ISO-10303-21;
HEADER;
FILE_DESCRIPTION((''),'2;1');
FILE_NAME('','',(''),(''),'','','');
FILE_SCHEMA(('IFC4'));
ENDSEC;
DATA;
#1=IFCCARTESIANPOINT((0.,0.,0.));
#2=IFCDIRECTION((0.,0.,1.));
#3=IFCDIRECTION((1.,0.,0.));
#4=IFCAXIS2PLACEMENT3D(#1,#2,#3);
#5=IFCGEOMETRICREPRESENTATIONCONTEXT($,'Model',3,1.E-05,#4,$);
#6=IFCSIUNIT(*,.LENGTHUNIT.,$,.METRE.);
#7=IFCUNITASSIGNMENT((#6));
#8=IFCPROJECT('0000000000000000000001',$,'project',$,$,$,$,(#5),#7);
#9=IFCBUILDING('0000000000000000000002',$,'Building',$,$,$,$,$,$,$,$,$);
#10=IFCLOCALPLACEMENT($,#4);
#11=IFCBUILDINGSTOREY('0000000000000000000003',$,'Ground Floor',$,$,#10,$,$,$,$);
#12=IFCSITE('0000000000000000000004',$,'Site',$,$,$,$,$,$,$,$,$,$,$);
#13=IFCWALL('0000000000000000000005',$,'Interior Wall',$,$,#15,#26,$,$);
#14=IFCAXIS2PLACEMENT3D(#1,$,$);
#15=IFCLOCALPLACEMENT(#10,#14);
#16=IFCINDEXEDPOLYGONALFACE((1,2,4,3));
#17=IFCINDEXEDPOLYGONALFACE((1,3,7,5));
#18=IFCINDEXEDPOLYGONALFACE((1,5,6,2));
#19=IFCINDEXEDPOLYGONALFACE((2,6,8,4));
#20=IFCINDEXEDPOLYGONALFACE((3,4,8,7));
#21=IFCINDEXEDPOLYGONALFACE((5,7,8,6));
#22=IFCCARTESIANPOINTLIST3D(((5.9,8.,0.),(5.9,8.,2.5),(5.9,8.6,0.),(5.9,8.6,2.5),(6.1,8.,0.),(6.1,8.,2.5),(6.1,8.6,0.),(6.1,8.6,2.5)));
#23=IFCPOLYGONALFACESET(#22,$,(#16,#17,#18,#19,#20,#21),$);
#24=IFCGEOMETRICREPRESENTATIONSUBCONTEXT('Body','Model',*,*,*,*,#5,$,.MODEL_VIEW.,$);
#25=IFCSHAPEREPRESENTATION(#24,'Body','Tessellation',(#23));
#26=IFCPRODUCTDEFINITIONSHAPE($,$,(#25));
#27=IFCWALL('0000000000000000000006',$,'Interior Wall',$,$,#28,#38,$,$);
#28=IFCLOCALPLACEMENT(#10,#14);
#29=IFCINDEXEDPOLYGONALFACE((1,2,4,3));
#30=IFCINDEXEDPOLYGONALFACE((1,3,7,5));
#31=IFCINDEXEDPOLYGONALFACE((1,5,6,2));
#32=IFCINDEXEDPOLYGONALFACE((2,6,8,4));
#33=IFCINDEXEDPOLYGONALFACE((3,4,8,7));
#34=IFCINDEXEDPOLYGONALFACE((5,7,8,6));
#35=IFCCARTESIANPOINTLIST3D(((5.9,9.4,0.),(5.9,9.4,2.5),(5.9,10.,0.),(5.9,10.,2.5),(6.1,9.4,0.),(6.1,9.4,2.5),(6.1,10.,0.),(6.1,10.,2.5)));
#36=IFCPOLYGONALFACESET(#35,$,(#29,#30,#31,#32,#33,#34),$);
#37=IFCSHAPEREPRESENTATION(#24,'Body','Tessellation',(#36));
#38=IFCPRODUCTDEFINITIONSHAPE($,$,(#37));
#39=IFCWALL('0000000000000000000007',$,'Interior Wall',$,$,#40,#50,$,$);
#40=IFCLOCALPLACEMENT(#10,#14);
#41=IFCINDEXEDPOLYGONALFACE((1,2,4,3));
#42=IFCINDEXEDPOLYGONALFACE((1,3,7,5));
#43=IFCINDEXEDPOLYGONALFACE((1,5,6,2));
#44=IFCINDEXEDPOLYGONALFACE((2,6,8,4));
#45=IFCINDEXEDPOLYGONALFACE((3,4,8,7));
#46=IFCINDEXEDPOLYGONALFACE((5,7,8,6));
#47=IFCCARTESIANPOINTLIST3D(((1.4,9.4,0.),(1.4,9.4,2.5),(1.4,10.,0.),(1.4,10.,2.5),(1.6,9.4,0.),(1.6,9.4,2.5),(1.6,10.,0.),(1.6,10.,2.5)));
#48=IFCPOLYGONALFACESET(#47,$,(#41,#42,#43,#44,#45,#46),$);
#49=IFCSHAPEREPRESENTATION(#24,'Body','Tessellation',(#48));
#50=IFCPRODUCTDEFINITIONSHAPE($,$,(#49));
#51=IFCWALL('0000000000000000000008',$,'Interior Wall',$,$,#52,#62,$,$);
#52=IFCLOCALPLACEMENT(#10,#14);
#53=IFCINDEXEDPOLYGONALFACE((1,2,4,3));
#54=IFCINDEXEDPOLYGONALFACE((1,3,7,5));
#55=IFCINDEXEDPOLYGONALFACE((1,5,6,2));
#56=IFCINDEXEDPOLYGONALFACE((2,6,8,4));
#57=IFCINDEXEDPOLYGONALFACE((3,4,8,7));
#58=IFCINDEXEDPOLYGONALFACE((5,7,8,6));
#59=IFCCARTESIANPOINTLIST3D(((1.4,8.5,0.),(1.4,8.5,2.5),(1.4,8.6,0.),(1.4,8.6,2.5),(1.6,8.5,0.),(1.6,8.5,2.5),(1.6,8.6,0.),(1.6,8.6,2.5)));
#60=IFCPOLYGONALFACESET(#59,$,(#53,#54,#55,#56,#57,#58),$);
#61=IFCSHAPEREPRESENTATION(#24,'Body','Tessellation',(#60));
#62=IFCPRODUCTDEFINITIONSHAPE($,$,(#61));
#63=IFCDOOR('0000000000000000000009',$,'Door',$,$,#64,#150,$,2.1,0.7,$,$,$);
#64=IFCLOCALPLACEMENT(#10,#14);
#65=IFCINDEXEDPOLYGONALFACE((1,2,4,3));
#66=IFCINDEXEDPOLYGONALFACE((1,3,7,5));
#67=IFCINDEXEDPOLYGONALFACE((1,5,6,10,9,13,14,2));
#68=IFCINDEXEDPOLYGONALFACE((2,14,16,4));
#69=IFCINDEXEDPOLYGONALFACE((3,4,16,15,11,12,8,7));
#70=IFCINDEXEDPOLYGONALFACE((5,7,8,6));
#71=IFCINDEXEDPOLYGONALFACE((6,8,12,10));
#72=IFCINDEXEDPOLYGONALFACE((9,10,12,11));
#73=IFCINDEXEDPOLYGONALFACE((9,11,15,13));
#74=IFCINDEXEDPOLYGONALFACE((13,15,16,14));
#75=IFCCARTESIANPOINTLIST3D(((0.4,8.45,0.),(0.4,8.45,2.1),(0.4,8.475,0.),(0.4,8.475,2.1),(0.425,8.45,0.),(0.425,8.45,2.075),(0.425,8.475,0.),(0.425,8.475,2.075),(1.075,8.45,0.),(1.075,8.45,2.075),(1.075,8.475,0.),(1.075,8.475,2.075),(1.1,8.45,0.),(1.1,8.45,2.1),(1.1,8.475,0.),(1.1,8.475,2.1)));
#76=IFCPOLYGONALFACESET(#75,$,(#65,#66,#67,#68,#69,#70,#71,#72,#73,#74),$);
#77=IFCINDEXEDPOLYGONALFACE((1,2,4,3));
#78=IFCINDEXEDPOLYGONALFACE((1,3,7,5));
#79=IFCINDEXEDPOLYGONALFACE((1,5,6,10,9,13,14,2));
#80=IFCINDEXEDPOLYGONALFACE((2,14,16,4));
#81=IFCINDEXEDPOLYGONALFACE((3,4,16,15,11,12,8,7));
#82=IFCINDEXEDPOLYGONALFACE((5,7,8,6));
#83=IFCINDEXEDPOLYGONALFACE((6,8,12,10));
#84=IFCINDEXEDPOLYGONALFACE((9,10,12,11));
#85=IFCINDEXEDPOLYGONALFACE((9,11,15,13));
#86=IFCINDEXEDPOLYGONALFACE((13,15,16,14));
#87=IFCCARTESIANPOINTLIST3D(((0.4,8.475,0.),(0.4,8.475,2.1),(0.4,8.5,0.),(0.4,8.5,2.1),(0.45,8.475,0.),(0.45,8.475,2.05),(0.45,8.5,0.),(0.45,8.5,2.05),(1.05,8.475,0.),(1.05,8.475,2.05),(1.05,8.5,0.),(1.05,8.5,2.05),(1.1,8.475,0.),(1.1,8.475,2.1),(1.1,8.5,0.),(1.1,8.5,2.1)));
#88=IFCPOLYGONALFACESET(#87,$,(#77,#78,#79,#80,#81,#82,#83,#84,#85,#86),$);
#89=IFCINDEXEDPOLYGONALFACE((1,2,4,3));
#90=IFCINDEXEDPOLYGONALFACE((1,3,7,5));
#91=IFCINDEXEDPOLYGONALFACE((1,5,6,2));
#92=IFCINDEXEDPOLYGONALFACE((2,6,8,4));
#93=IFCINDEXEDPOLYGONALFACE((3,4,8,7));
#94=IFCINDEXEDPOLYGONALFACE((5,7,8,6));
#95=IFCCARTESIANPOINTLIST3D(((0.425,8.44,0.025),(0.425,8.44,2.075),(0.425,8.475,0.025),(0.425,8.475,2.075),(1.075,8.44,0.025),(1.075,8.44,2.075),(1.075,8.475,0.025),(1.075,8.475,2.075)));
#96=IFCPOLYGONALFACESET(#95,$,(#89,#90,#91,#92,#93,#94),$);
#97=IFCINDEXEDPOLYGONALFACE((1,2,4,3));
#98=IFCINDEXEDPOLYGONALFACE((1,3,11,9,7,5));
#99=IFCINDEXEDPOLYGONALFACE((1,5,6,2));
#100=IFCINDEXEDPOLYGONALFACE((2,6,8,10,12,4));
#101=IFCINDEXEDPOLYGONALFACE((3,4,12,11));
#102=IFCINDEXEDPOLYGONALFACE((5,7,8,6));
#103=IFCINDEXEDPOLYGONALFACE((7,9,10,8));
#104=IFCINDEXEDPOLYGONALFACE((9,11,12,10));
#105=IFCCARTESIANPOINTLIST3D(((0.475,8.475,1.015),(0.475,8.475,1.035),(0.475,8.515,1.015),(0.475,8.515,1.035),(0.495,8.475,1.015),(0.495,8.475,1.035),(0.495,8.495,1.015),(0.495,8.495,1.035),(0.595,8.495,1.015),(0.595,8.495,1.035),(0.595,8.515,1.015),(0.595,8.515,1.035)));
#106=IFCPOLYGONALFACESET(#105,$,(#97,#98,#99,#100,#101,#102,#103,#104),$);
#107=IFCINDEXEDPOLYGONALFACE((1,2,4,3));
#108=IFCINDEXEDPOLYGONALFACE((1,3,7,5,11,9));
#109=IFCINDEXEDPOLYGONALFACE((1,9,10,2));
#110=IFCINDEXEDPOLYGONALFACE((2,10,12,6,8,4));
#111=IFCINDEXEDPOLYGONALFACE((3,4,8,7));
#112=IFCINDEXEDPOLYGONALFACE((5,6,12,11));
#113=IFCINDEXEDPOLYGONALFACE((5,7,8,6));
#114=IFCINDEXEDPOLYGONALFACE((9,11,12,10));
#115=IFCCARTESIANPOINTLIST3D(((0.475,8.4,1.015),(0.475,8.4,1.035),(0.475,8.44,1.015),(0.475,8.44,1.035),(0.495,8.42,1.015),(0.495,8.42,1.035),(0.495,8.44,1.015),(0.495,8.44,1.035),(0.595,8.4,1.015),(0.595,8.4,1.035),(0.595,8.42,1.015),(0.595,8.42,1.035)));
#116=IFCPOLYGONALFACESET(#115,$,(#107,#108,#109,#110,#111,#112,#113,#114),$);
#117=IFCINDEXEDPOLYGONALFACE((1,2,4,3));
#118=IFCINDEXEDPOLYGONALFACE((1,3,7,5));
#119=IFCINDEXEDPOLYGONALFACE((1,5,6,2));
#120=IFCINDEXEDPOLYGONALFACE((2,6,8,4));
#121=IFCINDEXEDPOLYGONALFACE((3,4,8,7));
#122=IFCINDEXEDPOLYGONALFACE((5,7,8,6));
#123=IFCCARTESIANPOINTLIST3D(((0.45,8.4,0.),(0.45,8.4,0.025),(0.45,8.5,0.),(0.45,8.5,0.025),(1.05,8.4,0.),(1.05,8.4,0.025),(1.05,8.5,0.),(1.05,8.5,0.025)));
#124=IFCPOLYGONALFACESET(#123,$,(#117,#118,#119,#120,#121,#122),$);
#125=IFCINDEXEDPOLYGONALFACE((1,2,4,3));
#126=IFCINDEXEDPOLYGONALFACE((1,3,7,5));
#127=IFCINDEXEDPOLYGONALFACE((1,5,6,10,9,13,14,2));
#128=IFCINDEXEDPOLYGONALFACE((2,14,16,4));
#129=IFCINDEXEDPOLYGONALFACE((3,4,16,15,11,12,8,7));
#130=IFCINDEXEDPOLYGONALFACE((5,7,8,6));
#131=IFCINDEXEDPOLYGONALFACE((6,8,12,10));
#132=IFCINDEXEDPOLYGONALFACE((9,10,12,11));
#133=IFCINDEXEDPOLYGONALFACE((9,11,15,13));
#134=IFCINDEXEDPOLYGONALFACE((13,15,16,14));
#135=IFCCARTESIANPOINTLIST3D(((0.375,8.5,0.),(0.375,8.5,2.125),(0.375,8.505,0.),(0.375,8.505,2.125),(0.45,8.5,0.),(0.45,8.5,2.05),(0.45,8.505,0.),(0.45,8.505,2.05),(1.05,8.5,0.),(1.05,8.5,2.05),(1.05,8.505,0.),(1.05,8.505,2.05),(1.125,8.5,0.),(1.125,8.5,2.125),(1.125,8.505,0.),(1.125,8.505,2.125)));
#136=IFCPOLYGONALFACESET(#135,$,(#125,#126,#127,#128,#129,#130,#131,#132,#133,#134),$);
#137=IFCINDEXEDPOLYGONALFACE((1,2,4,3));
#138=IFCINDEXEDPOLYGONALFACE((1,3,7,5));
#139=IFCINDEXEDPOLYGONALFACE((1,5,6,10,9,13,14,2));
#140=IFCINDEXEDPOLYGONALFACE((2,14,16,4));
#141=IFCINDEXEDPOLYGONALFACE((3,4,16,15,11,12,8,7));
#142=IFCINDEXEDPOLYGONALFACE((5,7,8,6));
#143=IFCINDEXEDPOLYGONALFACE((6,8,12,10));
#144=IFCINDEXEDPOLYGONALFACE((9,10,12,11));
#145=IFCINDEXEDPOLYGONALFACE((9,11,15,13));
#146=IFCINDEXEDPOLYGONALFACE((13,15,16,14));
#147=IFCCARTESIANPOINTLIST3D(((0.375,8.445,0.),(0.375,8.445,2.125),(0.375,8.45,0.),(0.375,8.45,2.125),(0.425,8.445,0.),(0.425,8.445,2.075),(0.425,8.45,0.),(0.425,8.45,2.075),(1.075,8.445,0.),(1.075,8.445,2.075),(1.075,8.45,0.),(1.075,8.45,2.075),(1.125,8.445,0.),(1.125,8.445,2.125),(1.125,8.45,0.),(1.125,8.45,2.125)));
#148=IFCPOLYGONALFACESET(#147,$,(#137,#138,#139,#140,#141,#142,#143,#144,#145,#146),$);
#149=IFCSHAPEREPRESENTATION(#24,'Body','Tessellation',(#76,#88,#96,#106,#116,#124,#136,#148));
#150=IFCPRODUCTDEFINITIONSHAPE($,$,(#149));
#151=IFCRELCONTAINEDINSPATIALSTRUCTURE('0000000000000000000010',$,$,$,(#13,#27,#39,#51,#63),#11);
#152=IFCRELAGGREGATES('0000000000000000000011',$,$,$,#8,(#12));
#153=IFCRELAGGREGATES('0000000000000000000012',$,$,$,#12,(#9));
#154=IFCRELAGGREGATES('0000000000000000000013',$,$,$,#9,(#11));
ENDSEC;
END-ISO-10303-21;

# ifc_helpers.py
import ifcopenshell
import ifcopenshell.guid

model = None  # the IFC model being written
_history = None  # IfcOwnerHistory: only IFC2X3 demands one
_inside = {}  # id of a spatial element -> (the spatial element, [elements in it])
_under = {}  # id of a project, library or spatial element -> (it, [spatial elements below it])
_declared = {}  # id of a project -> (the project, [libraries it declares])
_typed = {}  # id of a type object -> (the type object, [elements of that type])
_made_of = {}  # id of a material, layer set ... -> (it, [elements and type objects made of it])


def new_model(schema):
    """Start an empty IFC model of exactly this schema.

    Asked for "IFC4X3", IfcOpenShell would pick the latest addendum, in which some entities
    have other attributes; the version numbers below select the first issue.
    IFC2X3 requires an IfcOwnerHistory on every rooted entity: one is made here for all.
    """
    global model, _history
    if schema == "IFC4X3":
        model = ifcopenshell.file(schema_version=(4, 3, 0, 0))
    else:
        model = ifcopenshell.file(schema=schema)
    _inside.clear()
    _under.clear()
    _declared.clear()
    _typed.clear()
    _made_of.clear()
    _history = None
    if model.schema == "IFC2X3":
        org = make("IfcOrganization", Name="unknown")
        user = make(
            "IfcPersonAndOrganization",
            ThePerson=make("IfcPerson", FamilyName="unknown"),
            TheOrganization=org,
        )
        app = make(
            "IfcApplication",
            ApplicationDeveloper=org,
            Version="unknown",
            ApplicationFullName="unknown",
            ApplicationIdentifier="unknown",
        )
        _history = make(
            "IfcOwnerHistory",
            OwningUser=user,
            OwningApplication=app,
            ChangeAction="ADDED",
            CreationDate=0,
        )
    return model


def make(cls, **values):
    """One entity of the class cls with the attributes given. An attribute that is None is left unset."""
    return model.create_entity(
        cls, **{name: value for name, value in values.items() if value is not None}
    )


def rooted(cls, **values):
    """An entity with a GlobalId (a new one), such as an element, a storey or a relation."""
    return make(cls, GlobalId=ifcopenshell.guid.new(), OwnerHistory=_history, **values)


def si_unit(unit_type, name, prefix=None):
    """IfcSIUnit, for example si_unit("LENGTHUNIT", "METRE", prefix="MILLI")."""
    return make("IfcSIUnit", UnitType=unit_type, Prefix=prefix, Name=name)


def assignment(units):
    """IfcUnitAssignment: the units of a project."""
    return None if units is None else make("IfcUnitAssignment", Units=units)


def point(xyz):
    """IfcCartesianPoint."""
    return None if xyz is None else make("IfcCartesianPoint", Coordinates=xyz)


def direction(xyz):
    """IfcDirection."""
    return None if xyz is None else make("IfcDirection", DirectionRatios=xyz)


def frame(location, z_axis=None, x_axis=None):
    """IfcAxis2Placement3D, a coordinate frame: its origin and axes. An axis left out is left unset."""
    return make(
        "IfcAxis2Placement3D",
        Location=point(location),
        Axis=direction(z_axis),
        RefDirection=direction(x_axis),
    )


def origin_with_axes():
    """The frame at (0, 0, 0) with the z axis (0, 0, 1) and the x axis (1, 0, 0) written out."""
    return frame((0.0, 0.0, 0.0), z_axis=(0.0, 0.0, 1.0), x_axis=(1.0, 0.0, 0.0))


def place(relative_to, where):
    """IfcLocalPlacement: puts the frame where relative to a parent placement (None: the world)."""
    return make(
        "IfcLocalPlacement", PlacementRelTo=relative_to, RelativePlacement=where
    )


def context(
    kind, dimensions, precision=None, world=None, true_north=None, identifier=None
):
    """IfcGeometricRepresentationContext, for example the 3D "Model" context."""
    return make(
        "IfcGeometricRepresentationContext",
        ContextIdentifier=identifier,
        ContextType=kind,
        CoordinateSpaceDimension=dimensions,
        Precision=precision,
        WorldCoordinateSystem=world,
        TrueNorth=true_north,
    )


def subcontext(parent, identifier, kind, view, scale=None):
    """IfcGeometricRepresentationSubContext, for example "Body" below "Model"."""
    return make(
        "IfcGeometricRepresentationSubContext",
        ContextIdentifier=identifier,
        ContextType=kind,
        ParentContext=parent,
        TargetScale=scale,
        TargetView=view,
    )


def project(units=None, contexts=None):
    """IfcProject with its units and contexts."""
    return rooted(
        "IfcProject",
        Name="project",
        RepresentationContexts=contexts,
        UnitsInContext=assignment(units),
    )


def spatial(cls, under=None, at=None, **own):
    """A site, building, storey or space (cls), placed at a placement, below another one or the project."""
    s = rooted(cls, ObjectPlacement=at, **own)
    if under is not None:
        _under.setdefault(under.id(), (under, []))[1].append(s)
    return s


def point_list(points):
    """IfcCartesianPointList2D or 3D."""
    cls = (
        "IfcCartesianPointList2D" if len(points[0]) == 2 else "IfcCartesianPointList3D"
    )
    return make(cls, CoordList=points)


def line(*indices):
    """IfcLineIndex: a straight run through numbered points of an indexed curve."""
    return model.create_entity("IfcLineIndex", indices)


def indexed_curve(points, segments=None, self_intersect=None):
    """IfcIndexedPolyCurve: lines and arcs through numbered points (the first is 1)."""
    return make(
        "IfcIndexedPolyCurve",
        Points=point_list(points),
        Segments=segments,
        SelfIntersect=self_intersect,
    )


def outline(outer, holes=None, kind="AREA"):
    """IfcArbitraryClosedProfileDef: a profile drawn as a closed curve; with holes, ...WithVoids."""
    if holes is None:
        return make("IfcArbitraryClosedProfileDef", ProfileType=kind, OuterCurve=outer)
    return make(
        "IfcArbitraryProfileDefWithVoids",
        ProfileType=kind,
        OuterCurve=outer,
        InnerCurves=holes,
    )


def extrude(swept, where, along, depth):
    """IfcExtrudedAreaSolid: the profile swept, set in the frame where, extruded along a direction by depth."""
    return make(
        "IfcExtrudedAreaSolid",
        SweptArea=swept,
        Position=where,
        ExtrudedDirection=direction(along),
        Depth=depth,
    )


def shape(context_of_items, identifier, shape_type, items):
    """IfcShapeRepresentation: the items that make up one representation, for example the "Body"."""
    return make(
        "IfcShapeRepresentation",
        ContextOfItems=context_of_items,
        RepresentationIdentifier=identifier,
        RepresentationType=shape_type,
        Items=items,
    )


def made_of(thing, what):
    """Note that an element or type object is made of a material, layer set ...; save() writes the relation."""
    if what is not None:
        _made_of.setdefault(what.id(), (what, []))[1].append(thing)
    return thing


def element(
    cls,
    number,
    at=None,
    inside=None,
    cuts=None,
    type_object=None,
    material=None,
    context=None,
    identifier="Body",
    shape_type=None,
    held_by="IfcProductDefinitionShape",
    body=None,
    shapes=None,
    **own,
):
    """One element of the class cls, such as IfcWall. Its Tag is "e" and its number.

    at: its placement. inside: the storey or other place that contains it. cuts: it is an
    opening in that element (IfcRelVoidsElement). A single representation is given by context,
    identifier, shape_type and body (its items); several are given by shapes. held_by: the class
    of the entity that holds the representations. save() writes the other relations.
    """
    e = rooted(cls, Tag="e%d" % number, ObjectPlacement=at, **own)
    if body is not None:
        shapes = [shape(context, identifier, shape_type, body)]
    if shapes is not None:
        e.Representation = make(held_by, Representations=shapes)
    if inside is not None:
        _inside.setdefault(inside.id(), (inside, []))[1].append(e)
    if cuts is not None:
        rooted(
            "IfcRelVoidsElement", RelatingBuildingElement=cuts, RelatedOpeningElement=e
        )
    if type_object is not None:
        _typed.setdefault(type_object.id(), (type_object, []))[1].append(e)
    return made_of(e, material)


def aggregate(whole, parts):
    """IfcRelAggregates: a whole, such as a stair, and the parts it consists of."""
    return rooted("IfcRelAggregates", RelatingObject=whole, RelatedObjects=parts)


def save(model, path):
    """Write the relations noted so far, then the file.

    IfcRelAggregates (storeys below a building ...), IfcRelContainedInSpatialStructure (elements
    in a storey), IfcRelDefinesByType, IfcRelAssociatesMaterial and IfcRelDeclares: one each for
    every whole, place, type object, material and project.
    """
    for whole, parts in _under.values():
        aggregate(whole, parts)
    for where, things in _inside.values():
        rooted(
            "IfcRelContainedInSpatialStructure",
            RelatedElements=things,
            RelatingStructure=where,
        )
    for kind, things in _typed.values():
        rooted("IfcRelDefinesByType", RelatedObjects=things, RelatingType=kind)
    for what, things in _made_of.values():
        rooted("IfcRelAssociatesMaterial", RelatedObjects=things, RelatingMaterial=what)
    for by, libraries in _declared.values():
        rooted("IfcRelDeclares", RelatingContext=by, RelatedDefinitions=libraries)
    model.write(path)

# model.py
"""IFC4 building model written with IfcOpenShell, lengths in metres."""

from ifc_helpers import new_model, si_unit, frame, origin_with_axes, place, context, subcontext, project, spatial, line, indexed_curve, outline, extrude, element, save


model = new_model("IFC4")

# Units and contexts
model_context = context("Model", 3, precision=1e-05, world=origin_with_axes())
body_context = subcontext(model_context, "Body", "Model", "MODEL_VIEW")
ifc_project = project(units=[si_unit("LENGTHUNIT", "METRE")], contexts=[model_context])

# Site, building, storey
site = spatial("IfcSite", under=ifc_project, Name="Site")
building = spatial("IfcBuilding", under=site, Name="Building")
storey_placement = place(None, origin_with_axes())
storey = spatial("IfcBuildingStorey", under=building, at=storey_placement, Name="Ground Floor")

# Walls
for number, where, z_axis, x_axis, name in (
    (1, (6.0, 8.0, 0.0), (0.0, 0.0, 1.0), (0.0, 1.0, 0.0), "Interior Wall"),
    (2, (6.0, 9.4, 0.0), (0.0, 0.0, 1.0), (0.0, 1.0, 0.0), "Interior Wall"),
    (3, (1.5, 10.0, 0.0), (0.0, 0.0, 1.0), (0.0, -1.0, 0.0), "Interior Wall"),
):
    element("IfcWall", number, at=place(storey_placement, frame(where, z_axis=z_axis, x_axis=x_axis)), inside=storey, Name=name, context=body_context, shape_type="SweptSolid", body=[
        extrude(outline(indexed_curve([(0.0, 0.0), (0.0, 0.2), (0.6, 0.2), (0.6, 0.0), (0.0, 0.0)], self_intersect=False)), frame((0.0, -0.1, 0.0), z_axis=(0.0, 0.0, 1.0), x_axis=(1.0, 0.0, 0.0)), (0.0, 0.0, 1.0), 2.5),
    ])
wall_1_placement = place(storey_placement, frame((1.5, 8.6, 0.0), z_axis=(0.0, 0.0, 1.0), x_axis=(0.0, -1.0, 0.0)))
element("IfcWall", 4, at=wall_1_placement, inside=storey, Name="Interior Wall", context=body_context, shape_type="SweptSolid", body=[
    extrude(outline(indexed_curve([(0.0, 0.0), (0.0, 0.2), (0.1, 0.2), (0.1, 0.0), (0.0, 0.0)], self_intersect=False)), frame((0.0, -0.1, 0.0), z_axis=(0.0, 0.0, 1.0), x_axis=(1.0, 0.0, 0.0)), (0.0, 0.0, 1.0), 2.5),
])

# Door
door_1_placement = place(storey_placement, frame((1.1, 8.5, 0.0), z_axis=(0.0, 0.0, 1.0), x_axis=(-1.0, 0.0, 0.0)))
element("IfcDoor", 5, at=door_1_placement, inside=storey, Name="Door", OverallHeight=2.1, OverallWidth=0.7, context=body_context, shape_type="SweptSolid", body=[
    extrude(outline(indexed_curve([(0.0, 0.0), (0.0, 2.1), (0.7, 2.1), (0.7, 0.0), (0.675, 0.0), (0.675, 2.075), (0.025, 2.075), (0.025, 0.0)], segments=[line(1, 2, 3, 4, 5, 6, 7, 8, 1)])), frame((0.0, 0.025, 0.0), z_axis=(0.0, -1.0, 0.0), x_axis=(1.0, 0.0, 0.0)), (0.0, 0.0, -1.0), 0.025),
    extrude(outline(indexed_curve([(0.0, 0.0), (0.0, 2.1), (0.7, 2.1), (0.7, 0.0), (0.65, 0.0), (0.65, 2.05), (0.05, 2.05), (0.05, 0.0)], segments=[line(1, 2, 3, 4, 5, 6, 7, 8, 1)])), frame((0.0, 0.0, 0.0), z_axis=(0.0, -1.0, 0.0), x_axis=(1.0, 0.0, 0.0)), (0.0, 0.0, -1.0), 0.025),
    extrude(outline(indexed_curve([(0.0, 0.0), (0.65, 0.0), (0.65, 0.035), (0.0, 0.035)], segments=[line(1, 2, 3, 4, 1)])), frame((0.025, 0.025, 0.025), z_axis=(0.0, 0.0, 1.0), x_axis=(1.0, 0.0, 0.0)), (0.0, 0.0, 1.0), 2.05),
    extrude(outline(indexed_curve([(0.0, 0.0), (0.0, -0.04), (-0.12, -0.04), (-0.12, -0.02), (-0.02, -0.02), (-0.02, 0.0)], segments=[line(1, 2, 3, 4, 5, 6, 1)])), frame((0.625, 0.025, 1.015), z_axis=(0.0, 0.0, 1.0), x_axis=(1.0, 0.0, 0.0)), (0.0, 0.0, 1.0), 0.02),
    extrude(outline(indexed_curve([(0.0, 0.0), (0.0, 0.04), (-0.12, 0.04), (-0.12, 0.02), (-0.02, 0.02), (-0.02, 0.0)], segments=[line(1, 2, 3, 4, 5, 6, 1)])), frame((0.625, 0.06, 1.015), z_axis=(0.0, 0.0, 1.0), x_axis=(1.0, 0.0, 0.0)), (0.0, 0.0, 1.0), 0.02),
    extrude(outline(indexed_curve([(0.0, 0.0), (0.6, 0.0), (0.6, 0.1), (0.0, 0.1)], segments=[line(1, 2, 3, 4, 1)])), frame((0.05, 0.0, 0.0), z_axis=(0.0, 0.0, 1.0), x_axis=(1.0, 0.0, 0.0)), (0.0, 0.0, 1.0), 0.025),
    extrude(outline(indexed_curve([(0.0, 0.0), (0.0, 2.125), (0.75, 2.125), (0.75, 0.0), (0.675, 0.0), (0.675, 2.05), (0.075, 2.05), (0.075, 0.0)], segments=[line(1, 2, 3, 4, 5, 6, 7, 8, 1)])), frame((-0.025, -0.005, 0.0), z_axis=(0.0, -1.0, 0.0), x_axis=(1.0, 0.0, 0.0)), (0.0, 0.0, -1.0), 0.005),
    extrude(outline(indexed_curve([(0.0, 0.0), (0.0, 2.125), (0.75, 2.125), (0.75, 0.0), (0.7, 0.0), (0.7, 2.075), (0.05, 2.075), (0.05, 0.0)], segments=[line(1, 2, 3, 4, 5, 6, 7, 8, 1)])), frame((-0.025, 0.05, 0.0), z_axis=(0.0, -1.0, 0.0), x_axis=(1.0, 0.0, 0.0)), (0.0, 0.0, -1.0), 0.005),
])

save(model, "model.ifc")
